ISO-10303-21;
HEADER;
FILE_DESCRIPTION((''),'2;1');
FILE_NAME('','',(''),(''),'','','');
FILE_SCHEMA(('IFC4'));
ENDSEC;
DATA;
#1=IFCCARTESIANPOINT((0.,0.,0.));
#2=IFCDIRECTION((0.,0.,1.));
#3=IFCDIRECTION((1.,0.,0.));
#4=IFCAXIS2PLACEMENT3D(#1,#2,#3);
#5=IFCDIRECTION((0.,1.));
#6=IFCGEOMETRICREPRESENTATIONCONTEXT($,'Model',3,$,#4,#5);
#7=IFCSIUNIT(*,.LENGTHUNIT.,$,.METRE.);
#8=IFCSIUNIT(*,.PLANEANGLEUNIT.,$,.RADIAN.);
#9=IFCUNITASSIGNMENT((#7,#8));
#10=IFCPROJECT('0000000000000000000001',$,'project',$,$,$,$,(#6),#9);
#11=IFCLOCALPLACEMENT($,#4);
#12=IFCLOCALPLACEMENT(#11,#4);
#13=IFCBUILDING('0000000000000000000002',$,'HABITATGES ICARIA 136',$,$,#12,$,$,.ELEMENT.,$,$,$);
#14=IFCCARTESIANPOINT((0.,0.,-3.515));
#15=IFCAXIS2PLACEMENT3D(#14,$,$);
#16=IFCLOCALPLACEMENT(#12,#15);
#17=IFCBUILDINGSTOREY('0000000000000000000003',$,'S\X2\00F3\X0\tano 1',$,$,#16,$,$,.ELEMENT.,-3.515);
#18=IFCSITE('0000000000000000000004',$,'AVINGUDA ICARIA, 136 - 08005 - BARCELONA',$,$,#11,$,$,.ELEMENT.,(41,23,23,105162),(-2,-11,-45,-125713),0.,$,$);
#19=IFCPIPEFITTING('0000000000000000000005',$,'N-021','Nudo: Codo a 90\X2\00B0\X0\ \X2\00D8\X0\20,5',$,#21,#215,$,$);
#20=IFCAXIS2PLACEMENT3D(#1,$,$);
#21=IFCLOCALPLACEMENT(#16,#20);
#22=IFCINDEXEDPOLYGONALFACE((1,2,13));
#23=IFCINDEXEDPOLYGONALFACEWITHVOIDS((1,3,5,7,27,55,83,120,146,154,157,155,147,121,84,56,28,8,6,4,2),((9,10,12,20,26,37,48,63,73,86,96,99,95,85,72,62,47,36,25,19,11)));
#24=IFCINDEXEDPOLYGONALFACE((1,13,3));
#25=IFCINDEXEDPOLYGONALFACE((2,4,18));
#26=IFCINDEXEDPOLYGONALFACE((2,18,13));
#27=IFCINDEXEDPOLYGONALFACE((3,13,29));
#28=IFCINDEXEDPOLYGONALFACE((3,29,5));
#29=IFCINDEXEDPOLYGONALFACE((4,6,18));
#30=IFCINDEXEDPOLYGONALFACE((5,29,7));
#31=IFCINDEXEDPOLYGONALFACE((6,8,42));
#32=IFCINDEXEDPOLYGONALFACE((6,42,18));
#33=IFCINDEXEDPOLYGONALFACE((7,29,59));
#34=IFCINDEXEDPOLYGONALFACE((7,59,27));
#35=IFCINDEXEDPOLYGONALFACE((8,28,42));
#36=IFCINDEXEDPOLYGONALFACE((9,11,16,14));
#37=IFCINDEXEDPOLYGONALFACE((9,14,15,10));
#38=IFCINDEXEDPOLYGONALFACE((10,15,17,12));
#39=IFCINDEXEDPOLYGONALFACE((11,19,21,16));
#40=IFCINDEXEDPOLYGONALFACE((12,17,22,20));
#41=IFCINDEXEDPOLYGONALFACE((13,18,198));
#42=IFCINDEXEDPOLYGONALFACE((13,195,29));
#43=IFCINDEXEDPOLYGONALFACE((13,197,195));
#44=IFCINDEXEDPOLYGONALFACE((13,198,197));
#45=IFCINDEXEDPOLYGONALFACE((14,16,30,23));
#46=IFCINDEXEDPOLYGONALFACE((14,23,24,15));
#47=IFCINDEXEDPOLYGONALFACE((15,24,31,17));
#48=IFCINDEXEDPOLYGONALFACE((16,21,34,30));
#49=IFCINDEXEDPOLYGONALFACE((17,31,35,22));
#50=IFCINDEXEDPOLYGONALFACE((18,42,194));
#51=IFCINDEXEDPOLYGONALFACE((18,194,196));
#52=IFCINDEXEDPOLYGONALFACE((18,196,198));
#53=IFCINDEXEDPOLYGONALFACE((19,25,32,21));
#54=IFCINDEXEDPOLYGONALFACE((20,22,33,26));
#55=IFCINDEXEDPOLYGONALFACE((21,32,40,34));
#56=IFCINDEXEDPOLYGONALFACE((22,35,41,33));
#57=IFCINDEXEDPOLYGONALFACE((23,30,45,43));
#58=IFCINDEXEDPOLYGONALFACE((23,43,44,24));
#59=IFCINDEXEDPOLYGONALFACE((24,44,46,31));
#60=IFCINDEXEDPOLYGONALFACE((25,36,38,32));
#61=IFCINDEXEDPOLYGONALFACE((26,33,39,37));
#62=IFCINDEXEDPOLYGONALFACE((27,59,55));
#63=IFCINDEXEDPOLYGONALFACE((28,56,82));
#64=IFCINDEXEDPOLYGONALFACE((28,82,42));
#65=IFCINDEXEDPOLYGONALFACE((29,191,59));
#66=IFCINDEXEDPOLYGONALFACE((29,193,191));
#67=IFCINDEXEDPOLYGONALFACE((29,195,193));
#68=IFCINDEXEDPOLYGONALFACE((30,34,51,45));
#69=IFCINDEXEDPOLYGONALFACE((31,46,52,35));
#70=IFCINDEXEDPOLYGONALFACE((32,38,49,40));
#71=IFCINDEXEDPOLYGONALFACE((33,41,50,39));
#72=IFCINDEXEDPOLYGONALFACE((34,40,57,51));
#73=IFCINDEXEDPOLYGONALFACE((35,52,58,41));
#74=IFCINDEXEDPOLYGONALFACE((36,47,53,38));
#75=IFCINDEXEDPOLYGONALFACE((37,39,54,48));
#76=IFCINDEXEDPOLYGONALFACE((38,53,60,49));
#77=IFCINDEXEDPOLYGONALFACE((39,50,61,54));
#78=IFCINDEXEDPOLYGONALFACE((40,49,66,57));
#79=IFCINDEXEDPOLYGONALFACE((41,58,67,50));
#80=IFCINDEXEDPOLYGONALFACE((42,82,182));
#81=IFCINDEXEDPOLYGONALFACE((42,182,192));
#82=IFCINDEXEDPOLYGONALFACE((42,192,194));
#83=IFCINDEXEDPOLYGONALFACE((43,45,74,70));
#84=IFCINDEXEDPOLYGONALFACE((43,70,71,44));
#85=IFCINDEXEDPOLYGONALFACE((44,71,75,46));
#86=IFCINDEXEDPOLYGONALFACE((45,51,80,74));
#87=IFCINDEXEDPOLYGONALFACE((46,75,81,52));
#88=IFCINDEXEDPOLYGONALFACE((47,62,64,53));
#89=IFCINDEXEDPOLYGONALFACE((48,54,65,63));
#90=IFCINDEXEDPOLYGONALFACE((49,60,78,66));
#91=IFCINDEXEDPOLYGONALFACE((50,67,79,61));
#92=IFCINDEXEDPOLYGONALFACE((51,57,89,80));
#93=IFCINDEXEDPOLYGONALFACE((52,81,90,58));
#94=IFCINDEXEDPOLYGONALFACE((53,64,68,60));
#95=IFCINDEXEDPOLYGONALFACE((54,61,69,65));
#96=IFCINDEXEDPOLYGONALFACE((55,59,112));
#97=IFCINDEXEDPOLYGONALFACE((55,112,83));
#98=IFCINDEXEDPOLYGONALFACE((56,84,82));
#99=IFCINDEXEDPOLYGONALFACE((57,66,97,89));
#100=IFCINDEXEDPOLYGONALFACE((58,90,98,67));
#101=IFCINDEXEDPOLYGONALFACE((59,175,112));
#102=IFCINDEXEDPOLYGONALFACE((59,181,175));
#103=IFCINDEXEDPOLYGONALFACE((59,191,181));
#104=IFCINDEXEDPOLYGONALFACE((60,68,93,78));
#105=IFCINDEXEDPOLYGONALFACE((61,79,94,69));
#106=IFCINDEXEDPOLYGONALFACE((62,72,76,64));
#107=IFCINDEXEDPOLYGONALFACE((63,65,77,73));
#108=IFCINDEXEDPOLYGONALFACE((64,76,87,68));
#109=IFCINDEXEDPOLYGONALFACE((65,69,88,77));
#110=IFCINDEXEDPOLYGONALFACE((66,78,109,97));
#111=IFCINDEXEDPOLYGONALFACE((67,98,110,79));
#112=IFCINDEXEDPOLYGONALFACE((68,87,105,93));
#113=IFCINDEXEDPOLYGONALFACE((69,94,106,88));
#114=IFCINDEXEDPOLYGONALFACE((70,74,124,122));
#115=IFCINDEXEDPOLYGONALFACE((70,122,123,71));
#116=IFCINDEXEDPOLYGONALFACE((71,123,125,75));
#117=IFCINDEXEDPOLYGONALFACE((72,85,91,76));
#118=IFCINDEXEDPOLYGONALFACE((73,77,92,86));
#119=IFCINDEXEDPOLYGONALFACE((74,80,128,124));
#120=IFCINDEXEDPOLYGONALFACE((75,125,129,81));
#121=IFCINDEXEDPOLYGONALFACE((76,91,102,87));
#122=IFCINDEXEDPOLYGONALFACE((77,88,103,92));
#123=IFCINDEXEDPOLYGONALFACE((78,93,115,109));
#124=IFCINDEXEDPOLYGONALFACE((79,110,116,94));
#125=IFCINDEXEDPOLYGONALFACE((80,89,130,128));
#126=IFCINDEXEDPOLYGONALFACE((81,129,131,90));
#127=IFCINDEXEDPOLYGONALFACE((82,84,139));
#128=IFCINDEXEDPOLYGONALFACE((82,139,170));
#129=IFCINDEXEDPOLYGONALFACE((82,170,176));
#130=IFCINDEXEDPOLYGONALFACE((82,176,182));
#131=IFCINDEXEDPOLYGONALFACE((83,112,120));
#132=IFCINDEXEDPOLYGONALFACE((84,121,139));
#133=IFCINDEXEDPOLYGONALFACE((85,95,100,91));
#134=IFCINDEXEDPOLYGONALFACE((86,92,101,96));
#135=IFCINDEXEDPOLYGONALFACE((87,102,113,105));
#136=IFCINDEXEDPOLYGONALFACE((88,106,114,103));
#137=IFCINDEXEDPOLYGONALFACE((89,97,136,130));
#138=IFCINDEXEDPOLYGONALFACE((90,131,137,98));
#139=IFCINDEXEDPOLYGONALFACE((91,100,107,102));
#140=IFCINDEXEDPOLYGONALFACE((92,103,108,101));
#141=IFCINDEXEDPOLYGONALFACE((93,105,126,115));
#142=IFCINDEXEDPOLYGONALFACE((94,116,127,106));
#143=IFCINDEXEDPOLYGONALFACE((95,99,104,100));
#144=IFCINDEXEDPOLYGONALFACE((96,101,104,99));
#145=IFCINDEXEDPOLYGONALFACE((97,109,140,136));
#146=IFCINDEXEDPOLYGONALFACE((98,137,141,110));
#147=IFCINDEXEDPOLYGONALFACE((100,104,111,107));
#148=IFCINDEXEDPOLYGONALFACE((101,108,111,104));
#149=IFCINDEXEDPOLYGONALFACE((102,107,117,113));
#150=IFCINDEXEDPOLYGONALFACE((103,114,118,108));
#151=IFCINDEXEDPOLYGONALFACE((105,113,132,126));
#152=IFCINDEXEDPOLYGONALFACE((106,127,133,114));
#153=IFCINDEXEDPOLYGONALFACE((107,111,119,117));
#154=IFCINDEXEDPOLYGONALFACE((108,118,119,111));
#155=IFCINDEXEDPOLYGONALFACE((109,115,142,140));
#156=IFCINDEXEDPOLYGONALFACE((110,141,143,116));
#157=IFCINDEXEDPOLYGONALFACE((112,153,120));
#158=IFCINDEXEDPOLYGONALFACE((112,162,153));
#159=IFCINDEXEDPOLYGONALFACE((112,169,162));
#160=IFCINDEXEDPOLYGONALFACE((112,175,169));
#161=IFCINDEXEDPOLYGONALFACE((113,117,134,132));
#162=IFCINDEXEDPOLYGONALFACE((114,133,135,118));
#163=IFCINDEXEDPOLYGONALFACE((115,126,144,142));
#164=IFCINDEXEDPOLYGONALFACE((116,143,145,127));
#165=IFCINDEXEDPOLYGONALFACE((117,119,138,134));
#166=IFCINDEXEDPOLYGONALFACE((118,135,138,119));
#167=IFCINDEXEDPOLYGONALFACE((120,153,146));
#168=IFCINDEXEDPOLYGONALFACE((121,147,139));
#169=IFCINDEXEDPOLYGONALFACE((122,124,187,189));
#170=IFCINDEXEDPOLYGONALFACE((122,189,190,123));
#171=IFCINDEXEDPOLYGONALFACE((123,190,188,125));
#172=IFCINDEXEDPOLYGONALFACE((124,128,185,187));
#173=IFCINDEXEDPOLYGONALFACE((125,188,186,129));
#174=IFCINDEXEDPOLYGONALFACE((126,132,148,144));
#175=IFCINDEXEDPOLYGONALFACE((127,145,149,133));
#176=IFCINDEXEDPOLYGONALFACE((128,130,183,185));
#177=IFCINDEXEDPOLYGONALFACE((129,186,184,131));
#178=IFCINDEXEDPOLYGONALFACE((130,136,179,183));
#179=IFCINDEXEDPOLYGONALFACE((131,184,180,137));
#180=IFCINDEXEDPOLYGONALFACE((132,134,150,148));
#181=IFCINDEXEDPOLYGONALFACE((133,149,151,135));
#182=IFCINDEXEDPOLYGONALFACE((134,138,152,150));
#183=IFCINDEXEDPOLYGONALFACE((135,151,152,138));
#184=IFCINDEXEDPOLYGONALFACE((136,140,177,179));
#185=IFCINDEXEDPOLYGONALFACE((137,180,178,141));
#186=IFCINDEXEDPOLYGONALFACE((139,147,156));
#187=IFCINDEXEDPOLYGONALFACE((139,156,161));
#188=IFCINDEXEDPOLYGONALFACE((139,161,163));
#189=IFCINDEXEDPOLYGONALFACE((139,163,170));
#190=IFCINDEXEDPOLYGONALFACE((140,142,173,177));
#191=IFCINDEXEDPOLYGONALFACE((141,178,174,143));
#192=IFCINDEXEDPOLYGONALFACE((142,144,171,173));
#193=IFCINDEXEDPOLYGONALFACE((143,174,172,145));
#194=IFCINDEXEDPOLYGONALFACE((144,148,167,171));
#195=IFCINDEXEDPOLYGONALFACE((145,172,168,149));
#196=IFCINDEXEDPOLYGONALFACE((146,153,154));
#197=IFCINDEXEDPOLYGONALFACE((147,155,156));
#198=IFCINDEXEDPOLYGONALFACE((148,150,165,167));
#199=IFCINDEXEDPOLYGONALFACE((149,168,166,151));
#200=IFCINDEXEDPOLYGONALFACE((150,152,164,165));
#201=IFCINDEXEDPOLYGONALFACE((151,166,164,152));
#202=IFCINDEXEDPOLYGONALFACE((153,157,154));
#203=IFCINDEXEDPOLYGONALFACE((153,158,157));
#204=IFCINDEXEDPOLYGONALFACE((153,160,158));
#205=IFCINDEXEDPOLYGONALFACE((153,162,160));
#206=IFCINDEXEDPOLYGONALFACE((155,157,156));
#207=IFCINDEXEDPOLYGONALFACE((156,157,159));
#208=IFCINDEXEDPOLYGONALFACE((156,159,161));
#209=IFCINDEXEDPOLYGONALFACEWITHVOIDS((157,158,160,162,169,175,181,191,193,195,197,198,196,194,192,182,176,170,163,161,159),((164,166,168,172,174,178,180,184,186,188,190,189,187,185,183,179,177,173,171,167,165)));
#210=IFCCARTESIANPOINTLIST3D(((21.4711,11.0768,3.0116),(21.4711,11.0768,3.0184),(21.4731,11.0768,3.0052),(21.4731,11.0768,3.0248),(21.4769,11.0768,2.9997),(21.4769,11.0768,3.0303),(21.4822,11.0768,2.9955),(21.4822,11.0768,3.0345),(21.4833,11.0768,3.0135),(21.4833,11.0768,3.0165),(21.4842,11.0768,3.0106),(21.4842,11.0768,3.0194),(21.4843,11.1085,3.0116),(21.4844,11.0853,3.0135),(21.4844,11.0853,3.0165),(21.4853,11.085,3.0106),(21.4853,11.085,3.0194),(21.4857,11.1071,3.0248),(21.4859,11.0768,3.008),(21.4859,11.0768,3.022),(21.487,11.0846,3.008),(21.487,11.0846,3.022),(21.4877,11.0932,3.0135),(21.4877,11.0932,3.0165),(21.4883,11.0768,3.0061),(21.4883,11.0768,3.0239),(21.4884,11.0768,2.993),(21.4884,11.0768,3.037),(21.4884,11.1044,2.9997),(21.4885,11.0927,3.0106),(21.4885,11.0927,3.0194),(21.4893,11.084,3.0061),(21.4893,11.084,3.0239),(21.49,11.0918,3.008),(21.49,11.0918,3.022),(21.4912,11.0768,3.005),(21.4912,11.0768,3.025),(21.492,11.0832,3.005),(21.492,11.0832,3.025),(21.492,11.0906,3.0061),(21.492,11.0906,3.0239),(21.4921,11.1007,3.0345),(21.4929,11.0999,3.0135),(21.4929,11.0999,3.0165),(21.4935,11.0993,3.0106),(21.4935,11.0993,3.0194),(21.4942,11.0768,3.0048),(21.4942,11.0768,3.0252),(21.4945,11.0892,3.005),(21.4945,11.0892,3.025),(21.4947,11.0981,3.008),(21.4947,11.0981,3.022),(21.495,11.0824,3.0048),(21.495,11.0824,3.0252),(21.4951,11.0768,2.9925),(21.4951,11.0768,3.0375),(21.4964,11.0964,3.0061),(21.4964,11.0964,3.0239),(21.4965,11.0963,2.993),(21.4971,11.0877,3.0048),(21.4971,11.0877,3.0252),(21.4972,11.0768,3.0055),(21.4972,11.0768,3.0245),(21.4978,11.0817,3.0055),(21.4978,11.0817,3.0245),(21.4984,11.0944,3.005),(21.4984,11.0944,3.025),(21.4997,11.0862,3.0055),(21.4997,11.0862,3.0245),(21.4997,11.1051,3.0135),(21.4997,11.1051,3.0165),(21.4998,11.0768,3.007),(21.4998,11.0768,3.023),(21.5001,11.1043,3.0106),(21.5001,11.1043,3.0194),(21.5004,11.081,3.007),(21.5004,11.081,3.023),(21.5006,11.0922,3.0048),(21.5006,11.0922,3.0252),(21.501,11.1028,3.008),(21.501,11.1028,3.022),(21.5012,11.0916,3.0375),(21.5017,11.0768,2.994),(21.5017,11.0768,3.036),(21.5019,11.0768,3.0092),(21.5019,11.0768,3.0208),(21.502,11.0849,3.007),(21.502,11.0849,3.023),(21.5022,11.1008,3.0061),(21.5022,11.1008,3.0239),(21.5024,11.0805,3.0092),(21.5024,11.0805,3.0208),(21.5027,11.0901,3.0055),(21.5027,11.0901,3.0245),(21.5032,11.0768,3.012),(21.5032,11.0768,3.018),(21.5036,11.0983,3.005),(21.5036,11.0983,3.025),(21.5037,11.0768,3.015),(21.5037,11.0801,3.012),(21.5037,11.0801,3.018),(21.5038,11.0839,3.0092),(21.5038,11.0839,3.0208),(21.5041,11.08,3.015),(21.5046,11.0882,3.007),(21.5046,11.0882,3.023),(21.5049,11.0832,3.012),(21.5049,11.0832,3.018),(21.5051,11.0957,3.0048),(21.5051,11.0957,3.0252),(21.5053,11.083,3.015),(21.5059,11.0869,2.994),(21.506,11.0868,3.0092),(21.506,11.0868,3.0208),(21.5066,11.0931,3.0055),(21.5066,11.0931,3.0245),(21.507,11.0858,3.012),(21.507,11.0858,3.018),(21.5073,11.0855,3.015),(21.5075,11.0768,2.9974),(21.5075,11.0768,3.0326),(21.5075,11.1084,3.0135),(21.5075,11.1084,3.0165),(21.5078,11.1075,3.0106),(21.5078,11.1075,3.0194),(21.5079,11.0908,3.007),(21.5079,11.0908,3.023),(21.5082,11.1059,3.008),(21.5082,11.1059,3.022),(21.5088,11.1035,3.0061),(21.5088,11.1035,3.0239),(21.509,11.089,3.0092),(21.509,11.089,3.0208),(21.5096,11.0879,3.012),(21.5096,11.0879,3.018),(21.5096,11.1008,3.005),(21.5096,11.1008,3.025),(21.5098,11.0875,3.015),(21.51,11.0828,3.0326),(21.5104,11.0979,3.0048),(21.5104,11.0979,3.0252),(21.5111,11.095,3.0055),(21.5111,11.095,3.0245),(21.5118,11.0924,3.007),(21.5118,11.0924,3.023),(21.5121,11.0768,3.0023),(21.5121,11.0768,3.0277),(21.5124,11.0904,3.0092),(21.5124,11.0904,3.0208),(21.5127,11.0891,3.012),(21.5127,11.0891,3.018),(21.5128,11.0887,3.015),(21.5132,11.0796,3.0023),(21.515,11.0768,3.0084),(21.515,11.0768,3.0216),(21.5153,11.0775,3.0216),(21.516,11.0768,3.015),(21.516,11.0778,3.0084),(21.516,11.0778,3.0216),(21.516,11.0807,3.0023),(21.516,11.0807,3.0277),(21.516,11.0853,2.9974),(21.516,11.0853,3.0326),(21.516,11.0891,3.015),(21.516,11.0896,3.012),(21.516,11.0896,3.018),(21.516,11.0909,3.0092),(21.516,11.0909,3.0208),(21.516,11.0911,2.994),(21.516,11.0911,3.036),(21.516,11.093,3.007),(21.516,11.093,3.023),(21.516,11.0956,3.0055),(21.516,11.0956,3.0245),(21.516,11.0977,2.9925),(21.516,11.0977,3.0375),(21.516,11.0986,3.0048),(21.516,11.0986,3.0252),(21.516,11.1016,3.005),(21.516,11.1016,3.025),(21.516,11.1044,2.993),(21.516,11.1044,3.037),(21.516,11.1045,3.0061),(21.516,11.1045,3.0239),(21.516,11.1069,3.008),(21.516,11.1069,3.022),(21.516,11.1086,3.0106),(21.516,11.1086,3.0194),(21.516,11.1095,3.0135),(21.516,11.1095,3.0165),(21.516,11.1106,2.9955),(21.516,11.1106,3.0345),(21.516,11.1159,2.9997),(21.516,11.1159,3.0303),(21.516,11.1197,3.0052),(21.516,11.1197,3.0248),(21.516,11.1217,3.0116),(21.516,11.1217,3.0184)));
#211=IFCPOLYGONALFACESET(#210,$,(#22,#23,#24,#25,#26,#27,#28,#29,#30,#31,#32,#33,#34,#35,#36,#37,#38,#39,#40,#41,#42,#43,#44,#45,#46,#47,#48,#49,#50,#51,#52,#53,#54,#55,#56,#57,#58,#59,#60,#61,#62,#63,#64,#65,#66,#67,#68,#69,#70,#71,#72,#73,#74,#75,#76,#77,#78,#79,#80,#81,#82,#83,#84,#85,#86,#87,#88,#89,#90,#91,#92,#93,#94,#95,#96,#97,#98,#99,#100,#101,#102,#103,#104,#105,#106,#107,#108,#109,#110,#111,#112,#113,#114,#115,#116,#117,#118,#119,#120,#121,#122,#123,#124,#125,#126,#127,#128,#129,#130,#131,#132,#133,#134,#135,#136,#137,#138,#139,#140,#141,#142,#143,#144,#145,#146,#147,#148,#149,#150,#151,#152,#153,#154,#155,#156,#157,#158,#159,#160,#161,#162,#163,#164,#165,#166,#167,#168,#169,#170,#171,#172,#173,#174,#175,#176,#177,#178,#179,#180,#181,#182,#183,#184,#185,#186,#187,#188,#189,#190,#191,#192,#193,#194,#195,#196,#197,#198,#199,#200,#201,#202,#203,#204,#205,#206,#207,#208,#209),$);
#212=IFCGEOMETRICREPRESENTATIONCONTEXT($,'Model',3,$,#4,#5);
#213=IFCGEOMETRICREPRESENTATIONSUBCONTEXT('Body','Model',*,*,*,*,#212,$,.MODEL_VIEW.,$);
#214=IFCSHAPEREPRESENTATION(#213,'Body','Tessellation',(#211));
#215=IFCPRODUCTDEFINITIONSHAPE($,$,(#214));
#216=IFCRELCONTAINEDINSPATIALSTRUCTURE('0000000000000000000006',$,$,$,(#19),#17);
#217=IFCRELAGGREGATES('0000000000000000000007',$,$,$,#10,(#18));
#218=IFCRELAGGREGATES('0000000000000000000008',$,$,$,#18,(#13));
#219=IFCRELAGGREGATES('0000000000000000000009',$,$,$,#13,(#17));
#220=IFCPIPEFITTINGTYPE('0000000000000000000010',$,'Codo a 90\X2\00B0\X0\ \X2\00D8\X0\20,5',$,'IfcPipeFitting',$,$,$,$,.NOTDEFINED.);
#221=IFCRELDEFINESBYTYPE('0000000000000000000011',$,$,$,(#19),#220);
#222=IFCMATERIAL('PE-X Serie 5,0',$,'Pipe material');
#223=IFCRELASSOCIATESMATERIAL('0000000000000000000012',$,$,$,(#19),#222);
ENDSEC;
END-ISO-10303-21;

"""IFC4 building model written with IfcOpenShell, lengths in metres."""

from ifc_helpers import new_model, entity, si_unit, direction, frame, origin_with_axes, place, context, subcontext, project, spatial, source, transform, mapped, material, type_object, element, save


model = new_model("IFC4")

# Units and contexts
model_context_1 = context("Model", 3, world=origin_with_axes(), true_north=direction((0.0, 1.0)))
model_context_2 = context("Model", 3, world=origin_with_axes(), true_north=direction((0.0, 1.0)))
body_context_1 = subcontext(model_context_2, "Body", "Model", "MODEL_VIEW")
ifc_project = project(units=[si_unit("LENGTHUNIT", "METRE"), si_unit("PLANEANGLEUNIT", "RADIAN")], contexts=[model_context_1])

# Site, building, storey
site_placement = place(None, origin_with_axes())
site = spatial("IfcSite", under=ifc_project, at=site_placement, Name="AVINGUDA ICARIA, 136 - 08005 - BARCELONA", CompositionType="ELEMENT", RefLatitude=(41, 23, 23, 105162), RefLongitude=(-2, -11, -45, -125713), RefElevation=0.0)
building_placement = place(site_placement, origin_with_axes())
building = spatial("IfcBuilding", under=site, at=building_placement, Name="HABITATGES ICARIA 136", CompositionType="ELEMENT")
storey_placement = place(building_placement, frame((0.0, 0.0, -3.515)))
storey = spatial("IfcBuildingStorey", under=building, at=storey_placement, Name="Sótano 1", CompositionType="ELEMENT", Elevation=-3.515)

# Shared definitions
ifc_material_1 = material(Name="PE-X Serie 5,0", Category="Pipe material")
placement_1 = place(None, origin_with_axes())
placement_2 = place(placement_1, origin_with_axes())
placement_3 = place(placement_2, frame((0.0, 0.0, -3.515)))

# Pipe fitting
pipe_fitting_type_1 = type_object("IfcPipeFittingType", Name="Codo a 90° Ø20,5", ApplicableOccurrence="IfcPipeFitting", PredefinedType="NOTDEFINED")
shared_shape_1 = source(origin_with_axes(), body_context_1, "Body", "SweptSolid", [
    entity("IfcRevolvedAreaSolid", entity("IfcCircleHollowProfileDef", "AREA", None, entity("IfcAxis2Placement2D", entity("IfcCartesianPoint", [0.0, 0.0]), entity("IfcDirection", [1.0, 0.0])), 0.0226, 0.0123), entity("IfcAxis2Placement3D", entity("IfcCartesianPoint", [0.0226, 0.0, 0.0]), entity("IfcDirection", [-1.0, 0.0, 0.0]), entity("IfcDirection", [0.0, -1.0, 0.0])), entity("IfcAxis1Placement", entity("IfcCartesianPoint", [0.0226, 0.0, 0.0]), entity("IfcDirection", [0.0, 1.0, 0.0])), 1.570796),
])
pipe_fitting_1_placement = place(placement_3, origin_with_axes())
element("IfcPipeFitting", 1, at=pipe_fitting_1_placement, inside=storey, type_object=pipe_fitting_type_1, material=ifc_material_1, Name="N-021", Description="Nudo: Codo a 90° Ø20,5", context=body_context_1, shape_type="MappedRepresentation", body=[
    mapped(shared_shape_1, transform((21.4934, 11.0994, 3.015), x_axis=(0.0, -1.0, 0.0), y_axis=(-1.0, 0.0, 0.0), z_axis=(0.0, 0.0, -1.0), scale=1.0)),
])

save(model, "model.ifc")
